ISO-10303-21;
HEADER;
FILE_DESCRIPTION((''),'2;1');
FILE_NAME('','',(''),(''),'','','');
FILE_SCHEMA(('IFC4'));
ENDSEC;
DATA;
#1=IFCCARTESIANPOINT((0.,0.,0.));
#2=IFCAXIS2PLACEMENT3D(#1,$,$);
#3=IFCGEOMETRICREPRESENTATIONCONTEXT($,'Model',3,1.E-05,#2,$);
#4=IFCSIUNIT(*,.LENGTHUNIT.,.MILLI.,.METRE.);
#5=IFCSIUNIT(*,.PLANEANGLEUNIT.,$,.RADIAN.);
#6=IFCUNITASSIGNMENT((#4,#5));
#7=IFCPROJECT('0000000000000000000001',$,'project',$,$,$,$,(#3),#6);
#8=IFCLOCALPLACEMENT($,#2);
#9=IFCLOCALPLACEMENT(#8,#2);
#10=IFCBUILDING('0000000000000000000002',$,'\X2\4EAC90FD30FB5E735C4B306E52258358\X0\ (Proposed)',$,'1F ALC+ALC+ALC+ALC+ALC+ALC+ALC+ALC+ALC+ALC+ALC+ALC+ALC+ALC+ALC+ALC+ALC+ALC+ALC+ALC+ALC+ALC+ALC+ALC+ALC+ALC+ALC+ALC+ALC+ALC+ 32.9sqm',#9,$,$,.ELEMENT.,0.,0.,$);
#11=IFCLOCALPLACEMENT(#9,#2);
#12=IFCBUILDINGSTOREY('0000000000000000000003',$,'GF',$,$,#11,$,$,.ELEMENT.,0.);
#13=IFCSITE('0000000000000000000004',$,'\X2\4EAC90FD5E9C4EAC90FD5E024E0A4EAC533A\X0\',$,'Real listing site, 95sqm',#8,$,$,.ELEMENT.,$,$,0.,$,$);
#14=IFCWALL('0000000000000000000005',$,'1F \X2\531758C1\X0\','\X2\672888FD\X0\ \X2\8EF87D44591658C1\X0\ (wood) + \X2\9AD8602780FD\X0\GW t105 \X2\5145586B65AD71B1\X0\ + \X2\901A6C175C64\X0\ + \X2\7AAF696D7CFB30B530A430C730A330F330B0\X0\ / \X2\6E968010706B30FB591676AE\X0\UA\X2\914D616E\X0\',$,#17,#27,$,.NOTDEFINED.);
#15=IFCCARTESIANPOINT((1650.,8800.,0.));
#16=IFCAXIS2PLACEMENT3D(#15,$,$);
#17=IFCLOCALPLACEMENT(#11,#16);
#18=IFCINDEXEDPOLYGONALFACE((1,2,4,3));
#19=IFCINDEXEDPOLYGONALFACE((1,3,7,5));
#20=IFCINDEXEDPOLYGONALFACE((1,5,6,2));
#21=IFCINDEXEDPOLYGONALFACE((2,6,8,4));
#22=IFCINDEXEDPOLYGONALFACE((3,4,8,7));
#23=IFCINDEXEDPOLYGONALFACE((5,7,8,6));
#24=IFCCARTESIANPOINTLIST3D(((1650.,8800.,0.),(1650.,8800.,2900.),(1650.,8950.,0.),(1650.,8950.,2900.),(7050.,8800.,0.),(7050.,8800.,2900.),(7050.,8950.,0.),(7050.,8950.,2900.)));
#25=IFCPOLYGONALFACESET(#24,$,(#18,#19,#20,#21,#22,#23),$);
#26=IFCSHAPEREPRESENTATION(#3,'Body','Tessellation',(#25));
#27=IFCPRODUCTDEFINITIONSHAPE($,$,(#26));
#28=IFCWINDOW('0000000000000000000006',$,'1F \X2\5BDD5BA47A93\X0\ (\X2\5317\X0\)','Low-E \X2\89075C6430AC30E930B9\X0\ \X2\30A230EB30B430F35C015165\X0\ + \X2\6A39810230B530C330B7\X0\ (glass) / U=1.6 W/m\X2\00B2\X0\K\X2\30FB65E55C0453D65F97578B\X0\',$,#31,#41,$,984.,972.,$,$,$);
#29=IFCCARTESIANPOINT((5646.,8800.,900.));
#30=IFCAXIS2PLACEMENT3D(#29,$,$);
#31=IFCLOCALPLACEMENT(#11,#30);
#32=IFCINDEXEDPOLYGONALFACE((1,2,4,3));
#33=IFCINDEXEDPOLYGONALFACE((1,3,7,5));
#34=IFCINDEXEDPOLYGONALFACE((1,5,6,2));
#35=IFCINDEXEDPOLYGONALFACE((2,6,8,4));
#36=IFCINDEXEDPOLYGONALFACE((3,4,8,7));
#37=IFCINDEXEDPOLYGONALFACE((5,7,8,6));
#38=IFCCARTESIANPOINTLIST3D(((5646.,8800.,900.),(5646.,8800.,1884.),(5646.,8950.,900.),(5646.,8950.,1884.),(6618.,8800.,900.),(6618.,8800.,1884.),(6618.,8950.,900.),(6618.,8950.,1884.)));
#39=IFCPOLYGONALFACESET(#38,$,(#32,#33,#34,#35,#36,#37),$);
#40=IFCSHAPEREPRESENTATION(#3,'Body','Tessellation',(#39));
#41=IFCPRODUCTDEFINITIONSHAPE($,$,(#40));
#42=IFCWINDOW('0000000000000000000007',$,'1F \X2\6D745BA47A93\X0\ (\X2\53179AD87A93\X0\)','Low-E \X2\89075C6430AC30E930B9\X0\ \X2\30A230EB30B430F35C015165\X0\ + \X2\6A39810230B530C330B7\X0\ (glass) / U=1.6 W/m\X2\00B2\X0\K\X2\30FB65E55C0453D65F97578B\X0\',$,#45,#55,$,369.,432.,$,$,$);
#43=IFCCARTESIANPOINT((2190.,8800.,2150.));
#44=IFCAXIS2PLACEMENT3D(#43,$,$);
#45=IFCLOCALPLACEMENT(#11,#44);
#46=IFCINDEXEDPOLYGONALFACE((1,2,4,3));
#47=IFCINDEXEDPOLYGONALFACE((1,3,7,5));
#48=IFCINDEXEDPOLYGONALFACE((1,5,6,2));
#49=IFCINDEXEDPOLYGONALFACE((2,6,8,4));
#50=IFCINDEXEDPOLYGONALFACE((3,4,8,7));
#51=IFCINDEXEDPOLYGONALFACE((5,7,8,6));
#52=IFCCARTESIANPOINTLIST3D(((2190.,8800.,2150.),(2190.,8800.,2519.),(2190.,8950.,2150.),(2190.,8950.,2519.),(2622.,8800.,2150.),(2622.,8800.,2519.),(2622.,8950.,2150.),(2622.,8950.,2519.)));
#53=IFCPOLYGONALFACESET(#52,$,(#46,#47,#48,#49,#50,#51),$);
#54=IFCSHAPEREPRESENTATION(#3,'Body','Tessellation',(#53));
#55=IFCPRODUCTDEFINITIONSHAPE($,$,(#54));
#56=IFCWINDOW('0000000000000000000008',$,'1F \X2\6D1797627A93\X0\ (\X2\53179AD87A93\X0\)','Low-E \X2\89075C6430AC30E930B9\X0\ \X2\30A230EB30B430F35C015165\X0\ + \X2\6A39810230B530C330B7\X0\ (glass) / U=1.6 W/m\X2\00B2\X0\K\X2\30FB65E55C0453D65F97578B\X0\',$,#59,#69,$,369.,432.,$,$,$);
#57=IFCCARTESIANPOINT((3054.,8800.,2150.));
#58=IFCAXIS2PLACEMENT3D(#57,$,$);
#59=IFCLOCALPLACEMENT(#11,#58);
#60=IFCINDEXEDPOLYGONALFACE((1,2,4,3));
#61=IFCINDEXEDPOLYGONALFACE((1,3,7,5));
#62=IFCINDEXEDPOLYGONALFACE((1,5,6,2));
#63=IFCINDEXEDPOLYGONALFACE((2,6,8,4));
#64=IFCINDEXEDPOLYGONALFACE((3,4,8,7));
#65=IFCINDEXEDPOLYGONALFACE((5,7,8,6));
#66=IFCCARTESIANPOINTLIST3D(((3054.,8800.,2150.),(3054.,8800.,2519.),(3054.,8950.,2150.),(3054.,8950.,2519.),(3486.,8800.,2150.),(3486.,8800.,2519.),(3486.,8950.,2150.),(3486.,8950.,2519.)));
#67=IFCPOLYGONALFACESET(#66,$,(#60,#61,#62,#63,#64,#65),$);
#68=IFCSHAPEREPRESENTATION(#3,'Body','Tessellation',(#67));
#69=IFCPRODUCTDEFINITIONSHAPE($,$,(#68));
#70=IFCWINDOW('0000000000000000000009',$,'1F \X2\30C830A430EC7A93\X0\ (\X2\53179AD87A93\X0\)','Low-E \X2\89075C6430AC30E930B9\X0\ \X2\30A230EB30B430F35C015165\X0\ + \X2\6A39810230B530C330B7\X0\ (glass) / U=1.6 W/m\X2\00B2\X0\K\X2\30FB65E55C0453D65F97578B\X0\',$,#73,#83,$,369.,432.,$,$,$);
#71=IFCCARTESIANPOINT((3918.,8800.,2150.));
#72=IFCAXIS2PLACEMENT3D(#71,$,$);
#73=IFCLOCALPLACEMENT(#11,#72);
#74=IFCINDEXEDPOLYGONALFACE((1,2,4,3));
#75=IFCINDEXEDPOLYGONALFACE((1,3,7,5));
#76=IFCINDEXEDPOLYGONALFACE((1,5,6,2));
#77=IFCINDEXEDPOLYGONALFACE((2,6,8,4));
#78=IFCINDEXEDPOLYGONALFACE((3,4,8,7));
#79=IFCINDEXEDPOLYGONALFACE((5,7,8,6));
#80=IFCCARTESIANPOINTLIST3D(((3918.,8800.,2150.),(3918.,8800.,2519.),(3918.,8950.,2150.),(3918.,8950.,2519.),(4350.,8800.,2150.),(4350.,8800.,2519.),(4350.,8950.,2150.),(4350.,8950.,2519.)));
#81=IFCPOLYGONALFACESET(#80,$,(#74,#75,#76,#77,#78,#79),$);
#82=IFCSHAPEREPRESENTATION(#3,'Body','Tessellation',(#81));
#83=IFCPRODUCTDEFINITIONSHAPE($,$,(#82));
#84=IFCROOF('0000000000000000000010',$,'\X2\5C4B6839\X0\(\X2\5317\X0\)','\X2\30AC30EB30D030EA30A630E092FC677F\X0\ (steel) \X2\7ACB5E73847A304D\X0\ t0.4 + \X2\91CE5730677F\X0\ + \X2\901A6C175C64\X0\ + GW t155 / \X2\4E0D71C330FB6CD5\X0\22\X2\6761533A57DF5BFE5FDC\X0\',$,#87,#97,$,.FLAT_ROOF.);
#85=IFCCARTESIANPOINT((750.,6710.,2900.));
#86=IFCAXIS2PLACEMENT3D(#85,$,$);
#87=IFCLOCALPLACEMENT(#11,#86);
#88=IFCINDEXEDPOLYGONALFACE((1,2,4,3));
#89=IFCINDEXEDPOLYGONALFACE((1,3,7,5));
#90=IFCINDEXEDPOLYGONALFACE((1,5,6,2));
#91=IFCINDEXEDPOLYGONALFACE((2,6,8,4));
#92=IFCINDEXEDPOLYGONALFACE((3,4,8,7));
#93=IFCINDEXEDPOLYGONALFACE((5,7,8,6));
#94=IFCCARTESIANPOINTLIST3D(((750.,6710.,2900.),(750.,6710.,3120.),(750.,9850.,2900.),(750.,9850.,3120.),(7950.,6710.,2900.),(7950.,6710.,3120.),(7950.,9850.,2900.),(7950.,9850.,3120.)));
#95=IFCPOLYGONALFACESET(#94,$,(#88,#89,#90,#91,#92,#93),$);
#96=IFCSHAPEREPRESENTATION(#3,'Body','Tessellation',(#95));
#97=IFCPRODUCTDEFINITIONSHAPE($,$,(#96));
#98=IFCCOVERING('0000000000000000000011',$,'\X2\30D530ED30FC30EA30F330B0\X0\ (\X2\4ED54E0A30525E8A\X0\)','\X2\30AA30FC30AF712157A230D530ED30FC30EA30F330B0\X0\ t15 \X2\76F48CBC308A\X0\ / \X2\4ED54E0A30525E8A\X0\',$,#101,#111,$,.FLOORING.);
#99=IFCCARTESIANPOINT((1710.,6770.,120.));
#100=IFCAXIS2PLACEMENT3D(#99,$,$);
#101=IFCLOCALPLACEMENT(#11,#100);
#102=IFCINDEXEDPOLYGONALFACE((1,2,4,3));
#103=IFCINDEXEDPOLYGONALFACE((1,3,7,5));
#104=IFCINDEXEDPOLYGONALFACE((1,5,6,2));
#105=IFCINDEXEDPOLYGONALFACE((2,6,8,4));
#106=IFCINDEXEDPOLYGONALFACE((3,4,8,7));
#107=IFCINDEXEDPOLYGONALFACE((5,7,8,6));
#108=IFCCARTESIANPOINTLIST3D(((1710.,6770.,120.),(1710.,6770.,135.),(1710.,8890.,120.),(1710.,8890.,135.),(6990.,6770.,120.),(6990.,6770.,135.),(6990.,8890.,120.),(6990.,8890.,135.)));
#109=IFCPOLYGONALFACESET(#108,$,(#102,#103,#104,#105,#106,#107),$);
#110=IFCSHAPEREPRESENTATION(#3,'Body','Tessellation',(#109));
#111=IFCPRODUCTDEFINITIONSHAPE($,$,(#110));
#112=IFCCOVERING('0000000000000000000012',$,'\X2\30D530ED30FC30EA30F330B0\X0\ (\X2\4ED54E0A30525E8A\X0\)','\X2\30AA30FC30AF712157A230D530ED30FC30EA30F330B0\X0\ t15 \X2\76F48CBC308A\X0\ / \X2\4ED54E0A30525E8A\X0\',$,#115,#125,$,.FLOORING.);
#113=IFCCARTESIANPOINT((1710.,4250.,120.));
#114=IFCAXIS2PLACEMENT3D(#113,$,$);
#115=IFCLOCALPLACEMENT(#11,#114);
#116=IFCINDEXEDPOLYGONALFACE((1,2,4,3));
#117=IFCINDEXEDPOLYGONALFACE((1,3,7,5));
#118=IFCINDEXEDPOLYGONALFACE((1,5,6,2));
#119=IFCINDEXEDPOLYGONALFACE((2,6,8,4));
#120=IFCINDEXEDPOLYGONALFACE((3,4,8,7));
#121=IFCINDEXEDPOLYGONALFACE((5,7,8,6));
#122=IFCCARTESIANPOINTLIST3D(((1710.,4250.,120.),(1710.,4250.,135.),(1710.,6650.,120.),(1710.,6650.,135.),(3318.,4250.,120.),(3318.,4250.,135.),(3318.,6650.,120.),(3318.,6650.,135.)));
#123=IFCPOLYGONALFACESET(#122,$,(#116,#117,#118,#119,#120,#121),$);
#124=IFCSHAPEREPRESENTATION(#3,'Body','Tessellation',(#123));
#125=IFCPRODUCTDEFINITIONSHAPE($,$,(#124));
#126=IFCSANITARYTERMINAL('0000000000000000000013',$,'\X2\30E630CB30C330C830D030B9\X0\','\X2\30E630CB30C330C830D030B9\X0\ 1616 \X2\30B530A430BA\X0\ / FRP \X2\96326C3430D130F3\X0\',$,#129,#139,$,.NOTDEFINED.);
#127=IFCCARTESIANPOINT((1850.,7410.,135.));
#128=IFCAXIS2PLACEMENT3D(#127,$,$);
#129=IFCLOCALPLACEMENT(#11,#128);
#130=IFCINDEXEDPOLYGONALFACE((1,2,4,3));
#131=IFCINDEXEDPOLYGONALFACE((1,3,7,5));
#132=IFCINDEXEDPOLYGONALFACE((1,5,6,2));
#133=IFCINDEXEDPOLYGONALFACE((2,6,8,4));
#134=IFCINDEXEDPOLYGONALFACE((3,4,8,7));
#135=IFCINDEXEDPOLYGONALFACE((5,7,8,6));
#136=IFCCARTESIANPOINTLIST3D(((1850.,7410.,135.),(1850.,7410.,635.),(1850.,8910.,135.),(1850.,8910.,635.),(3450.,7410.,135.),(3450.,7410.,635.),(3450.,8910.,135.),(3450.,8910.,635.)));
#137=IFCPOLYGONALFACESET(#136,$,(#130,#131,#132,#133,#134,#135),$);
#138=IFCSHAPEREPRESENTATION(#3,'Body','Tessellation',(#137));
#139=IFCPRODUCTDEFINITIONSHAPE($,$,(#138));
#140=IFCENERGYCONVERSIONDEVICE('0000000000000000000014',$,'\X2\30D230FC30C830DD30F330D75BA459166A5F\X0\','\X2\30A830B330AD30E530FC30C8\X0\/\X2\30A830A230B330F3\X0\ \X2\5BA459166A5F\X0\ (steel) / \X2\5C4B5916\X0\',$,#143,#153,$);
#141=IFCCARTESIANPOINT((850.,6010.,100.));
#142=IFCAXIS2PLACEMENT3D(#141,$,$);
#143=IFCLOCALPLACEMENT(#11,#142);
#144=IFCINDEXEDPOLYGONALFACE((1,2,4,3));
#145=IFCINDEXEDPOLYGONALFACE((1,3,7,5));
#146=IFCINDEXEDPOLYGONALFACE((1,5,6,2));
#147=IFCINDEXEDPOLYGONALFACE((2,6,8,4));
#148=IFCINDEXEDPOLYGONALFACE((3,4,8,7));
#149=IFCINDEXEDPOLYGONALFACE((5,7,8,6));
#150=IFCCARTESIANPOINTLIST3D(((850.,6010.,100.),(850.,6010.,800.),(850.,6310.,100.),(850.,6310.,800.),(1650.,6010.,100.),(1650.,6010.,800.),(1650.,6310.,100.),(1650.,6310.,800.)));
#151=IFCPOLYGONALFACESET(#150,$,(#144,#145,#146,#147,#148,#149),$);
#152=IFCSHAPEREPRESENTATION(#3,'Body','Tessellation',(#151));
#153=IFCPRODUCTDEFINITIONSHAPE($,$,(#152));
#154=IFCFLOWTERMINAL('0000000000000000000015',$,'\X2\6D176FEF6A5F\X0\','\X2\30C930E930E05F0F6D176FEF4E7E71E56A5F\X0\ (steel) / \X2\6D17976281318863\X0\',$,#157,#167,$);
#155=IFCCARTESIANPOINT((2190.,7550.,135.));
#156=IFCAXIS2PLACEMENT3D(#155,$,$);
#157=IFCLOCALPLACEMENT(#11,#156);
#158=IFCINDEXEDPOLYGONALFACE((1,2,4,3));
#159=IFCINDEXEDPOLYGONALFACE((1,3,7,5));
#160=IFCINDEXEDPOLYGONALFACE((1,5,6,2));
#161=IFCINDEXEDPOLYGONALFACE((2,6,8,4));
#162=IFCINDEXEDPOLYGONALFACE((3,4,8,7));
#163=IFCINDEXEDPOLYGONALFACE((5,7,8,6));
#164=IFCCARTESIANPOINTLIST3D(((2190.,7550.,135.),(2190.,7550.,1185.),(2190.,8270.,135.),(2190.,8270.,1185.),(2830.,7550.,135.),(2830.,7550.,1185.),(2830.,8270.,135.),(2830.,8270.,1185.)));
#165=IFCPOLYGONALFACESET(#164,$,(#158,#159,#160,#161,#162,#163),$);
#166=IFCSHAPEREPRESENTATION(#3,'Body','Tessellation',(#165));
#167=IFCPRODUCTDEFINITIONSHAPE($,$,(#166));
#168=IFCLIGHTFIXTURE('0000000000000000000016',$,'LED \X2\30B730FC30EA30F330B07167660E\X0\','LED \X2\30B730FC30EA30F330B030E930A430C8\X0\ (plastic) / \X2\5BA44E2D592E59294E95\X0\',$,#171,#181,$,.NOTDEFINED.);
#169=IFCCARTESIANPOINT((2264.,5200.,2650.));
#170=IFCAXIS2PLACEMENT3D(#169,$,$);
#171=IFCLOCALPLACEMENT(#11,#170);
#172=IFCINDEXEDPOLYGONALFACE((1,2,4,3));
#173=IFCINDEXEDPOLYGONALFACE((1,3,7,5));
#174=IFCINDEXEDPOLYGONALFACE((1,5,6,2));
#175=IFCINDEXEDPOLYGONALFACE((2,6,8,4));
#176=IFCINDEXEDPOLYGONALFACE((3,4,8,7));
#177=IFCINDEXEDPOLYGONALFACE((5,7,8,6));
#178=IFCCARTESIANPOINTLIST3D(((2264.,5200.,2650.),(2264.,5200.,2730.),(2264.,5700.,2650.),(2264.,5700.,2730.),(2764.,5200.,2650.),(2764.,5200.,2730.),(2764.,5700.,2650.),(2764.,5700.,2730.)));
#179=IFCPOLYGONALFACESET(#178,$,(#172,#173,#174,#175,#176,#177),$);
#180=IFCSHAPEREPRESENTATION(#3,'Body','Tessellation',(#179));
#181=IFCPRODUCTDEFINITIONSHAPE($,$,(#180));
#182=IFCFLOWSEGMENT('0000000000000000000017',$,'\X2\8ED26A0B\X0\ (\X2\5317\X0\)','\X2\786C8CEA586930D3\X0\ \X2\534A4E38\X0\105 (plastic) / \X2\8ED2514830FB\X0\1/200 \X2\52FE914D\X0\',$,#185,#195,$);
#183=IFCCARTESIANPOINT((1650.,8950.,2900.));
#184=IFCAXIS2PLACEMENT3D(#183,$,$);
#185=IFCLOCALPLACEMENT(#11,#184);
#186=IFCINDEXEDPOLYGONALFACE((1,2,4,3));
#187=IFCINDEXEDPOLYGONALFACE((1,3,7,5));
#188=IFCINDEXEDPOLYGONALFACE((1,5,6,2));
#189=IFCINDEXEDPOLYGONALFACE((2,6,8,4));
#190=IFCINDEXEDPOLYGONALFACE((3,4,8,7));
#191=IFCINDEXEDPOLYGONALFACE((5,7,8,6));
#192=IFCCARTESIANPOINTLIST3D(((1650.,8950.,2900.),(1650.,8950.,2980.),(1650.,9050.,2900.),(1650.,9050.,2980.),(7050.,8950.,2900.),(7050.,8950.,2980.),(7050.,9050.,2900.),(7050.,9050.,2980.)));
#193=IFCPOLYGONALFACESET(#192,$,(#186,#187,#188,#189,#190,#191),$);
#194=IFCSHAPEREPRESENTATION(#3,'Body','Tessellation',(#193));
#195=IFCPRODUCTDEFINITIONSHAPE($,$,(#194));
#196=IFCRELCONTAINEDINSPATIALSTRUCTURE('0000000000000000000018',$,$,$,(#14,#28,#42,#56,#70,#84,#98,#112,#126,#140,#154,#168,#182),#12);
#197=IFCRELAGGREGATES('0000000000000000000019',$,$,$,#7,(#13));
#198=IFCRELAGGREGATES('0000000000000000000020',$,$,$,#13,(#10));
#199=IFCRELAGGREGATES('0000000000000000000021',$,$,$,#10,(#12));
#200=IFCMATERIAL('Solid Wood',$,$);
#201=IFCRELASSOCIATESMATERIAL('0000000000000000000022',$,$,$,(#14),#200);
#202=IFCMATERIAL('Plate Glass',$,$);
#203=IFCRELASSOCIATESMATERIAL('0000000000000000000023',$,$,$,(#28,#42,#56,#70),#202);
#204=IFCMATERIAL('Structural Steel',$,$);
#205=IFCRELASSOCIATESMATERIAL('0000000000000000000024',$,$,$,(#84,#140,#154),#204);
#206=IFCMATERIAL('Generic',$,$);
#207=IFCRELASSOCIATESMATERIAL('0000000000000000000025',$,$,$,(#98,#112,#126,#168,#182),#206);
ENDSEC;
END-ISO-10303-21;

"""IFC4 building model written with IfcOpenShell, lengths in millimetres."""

from ifc_helpers import new_model, si_unit, frame, frame_2d, origin, place, context, project, spatial, rectangle, extrude, material, element, fill, save


model = new_model("IFC4")

# Units and contexts
model_context = context("Model", 3, precision=1e-05, world=origin())
ifc_project = project(units=[si_unit("LENGTHUNIT", "METRE", prefix="MILLI"), si_unit("PLANEANGLEUNIT", "RADIAN")], contexts=[model_context])

# Site, building, storey
site_placement = place(None, origin())
site = spatial("IfcSite", under=ifc_project, at=site_placement, Name="京都府京都市上京区", ObjectType="Real listing site, 95sqm", CompositionType="ELEMENT", RefElevation=0.0)
building_placement = place(site_placement, origin())
building = spatial("IfcBuilding", under=site, at=building_placement, Name="京都・平屋の別荘 (Proposed)", ObjectType="1F ALC+ALC+ALC+ALC+ALC+ALC+ALC+ALC+ALC+ALC+ALC+ALC+ALC+ALC+ALC+ALC+ALC+ALC+ALC+ALC+ALC+ALC+ALC+ALC+ALC+ALC+ALC+ALC+ALC+ALC+ 32.9sqm", CompositionType="ELEMENT", ElevationOfRefHeight=0.0, ElevationOfTerrain=0.0)
storey_placement = place(building_placement, origin())
storey = spatial("IfcBuildingStorey", under=building, at=storey_placement, Name="GF", CompositionType="ELEMENT", Elevation=0.0)

# Shared definitions
ifc_material_1 = material(Name="Solid Wood")

# Wall, openings, windows
wall_1_placement = place(storey_placement, frame((1650.0, 8800.0, 0.0)))
wall_1 = element("IfcWall", 1, at=wall_1_placement, inside=storey, material=ifc_material_1, Name="1F 北壁", Description="木製 軸組外壁 (wood) + 高性能GW t105 充填断熱 + 通気層 + 窯業系サイディング / 準耐火・外皮UA配慮", PredefinedType="NOTDEFINED", context=model_context, shape_type="SweptSolid", body=[
    extrude(rectangle(XDim=5400.0, YDim=150.0, at=frame_2d((2700.0, 75.0))), frame((1650.0, 8800.0, 0.0)), (0.0, 0.0, 1.0), 2900.0),
])
opening_1_placement = place(storey_placement, frame((5646.0, 8800.0, 900.0)))
opening_1 = element("IfcOpeningElement", 2, at=opening_1_placement, cuts=wall_1, PredefinedType="NOTDEFINED", context=model_context, shape_type="SweptSolid", body=[
    extrude(rectangle(XDim=972.0, YDim=150.0, at=frame_2d((486.0, 75.0))), frame((5646.0, 8800.0, 900.0)), (0.0, 0.0, 1.0), 984.0),
])
opening_2_placement = place(storey_placement, frame((2190.0, 8800.0, 2150.0)))
opening_2 = element("IfcOpeningElement", 3, at=opening_2_placement, cuts=wall_1, PredefinedType="NOTDEFINED", context=model_context, shape_type="SweptSolid", body=[
    extrude(rectangle(XDim=432.0, YDim=150.0, at=frame_2d((216.0, 75.0))), frame((2190.0, 8800.0, 2150.0)), (0.0, 0.0, 1.0), 369.0),
])
opening_3_placement = place(storey_placement, frame((3054.0, 8800.0, 2150.0)))
opening_3 = element("IfcOpeningElement", 4, at=opening_3_placement, cuts=wall_1, PredefinedType="NOTDEFINED", context=model_context, shape_type="SweptSolid", body=[
    extrude(rectangle(XDim=432.0, YDim=150.0, at=frame_2d((216.0, 75.0))), frame((3054.0, 8800.0, 2150.0)), (0.0, 0.0, 1.0), 369.0),
])
opening_4_placement = place(storey_placement, frame((3918.0, 8800.0, 2150.0)))
opening_4 = element("IfcOpeningElement", 5, at=opening_4_placement, cuts=wall_1, PredefinedType="NOTDEFINED", context=model_context, shape_type="SweptSolid", body=[
    extrude(rectangle(XDim=432.0, YDim=150.0, at=frame_2d((216.0, 75.0))), frame((3918.0, 8800.0, 2150.0)), (0.0, 0.0, 1.0), 369.0),
])
ifc_material_2 = material(Name="Plate Glass")
window_1_placement = place(storey_placement, frame((5646.0, 8800.0, 900.0)))
window_1 = element("IfcWindow", 6, at=window_1_placement, inside=storey, material=ifc_material_2, Name="1F 寝室窓 (北)", Description="Low-E 複層ガラス アルゴン封入 + 樹脂サッシ (glass) / U=1.6 W/m²K・日射取得型", OverallHeight=984.0, OverallWidth=972.0, context=model_context, shape_type="SweptSolid", body=[
    extrude(rectangle(XDim=972.0, YDim=150.0, at=frame_2d((486.0, 75.0))), frame((5646.0, 8800.0, 900.0)), (0.0, 0.0, 1.0), 984.0),
])
fill(opening_1, window_1)
window_2_placement = place(storey_placement, frame((2190.0, 8800.0, 2150.0)))
window_2 = element("IfcWindow", 7, at=window_2_placement, inside=storey, material=ifc_material_2, Name="1F 浴室窓 (北高窓)", Description="Low-E 複層ガラス アルゴン封入 + 樹脂サッシ (glass) / U=1.6 W/m²K・日射取得型", OverallHeight=369.0, OverallWidth=432.0, context=model_context, shape_type="SweptSolid", body=[
    extrude(rectangle(XDim=432.0, YDim=150.0, at=frame_2d((216.0, 75.0))), frame((2190.0, 8800.0, 2150.0)), (0.0, 0.0, 1.0), 369.0),
])
fill(opening_2, window_2)
window_3_placement = place(storey_placement, frame((3054.0, 8800.0, 2150.0)))
window_3 = element("IfcWindow", 8, at=window_3_placement, inside=storey, material=ifc_material_2, Name="1F 洗面窓 (北高窓)", Description="Low-E 複層ガラス アルゴン封入 + 樹脂サッシ (glass) / U=1.6 W/m²K・日射取得型", OverallHeight=369.0, OverallWidth=432.0, context=model_context, shape_type="SweptSolid", body=[
    extrude(rectangle(XDim=432.0, YDim=150.0, at=frame_2d((216.0, 75.0))), frame((3054.0, 8800.0, 2150.0)), (0.0, 0.0, 1.0), 369.0),
])
fill(opening_3, window_3)
window_4_placement = place(storey_placement, frame((3918.0, 8800.0, 2150.0)))
window_4 = element("IfcWindow", 9, at=window_4_placement, inside=storey, material=ifc_material_2, Name="1F トイレ窓 (北高窓)", Description="Low-E 複層ガラス アルゴン封入 + 樹脂サッシ (glass) / U=1.6 W/m²K・日射取得型", OverallHeight=369.0, OverallWidth=432.0, context=model_context, shape_type="SweptSolid", body=[
    extrude(rectangle(XDim=432.0, YDim=150.0, at=frame_2d((216.0, 75.0))), frame((3918.0, 8800.0, 2150.0)), (0.0, 0.0, 1.0), 369.0),
])
fill(opening_4, window_4)

# Roof
ifc_material_3 = material(Name="Structural Steel")
roof_placement = place(storey_placement, frame((750.0, 6710.0, 2900.0)))
element("IfcRoof", 10, at=roof_placement, inside=storey, material=ifc_material_3, Name="屋根(北)", Description="ガルバリウム鋼板 (steel) 立平葺き t0.4 + 野地板 + 通気層 + GW t155 / 不燃・法22条区域対応", PredefinedType="FLAT_ROOF", context=model_context, shape_type="SweptSolid", body=[
    extrude(rectangle(XDim=7200.0, YDim=3140.0, at=frame_2d((3600.0, 1570.0))), frame((750.0, 6710.0, 2900.0)), (0.0, 0.0, 1.0), 220.0),
])

# Coverings
ifc_material_4 = material(Name="Generic")
covering_1_placement = place(storey_placement, frame((1710.0, 6770.0, 120.0)))
element("IfcCovering", 11, at=covering_1_placement, inside=storey, material=ifc_material_4, Name="フローリング (仕上げ床)", Description="オーク無垢フローリング t15 直貼り / 仕上げ床", PredefinedType="FLOORING", context=model_context, shape_type="SweptSolid", body=[
    extrude(rectangle(XDim=5280.0, YDim=2120.0, at=frame_2d((2640.0, 1060.0))), frame((1710.0, 6770.0, 120.0)), (0.0, 0.0, 1.0), 15.0),
])
covering_2_placement = place(storey_placement, frame((1710.0, 4250.0, 120.0)))
element("IfcCovering", 12, at=covering_2_placement, inside=storey, material=ifc_material_4, Name="フローリング (仕上げ床)", Description="オーク無垢フローリング t15 直貼り / 仕上げ床", PredefinedType="FLOORING", context=model_context, shape_type="SweptSolid", body=[
    extrude(rectangle(XDim=1608.0, YDim=2400.0, at=frame_2d((804.0, 1200.0))), frame((1710.0, 4250.0, 120.0)), (0.0, 0.0, 1.0), 15.0),
])

# Sanitary terminal
sanitary_terminal_placement = place(storey_placement, frame((1850.0, 7410.0, 135.0)))
element("IfcSanitaryTerminal", 13, at=sanitary_terminal_placement, inside=storey, material=ifc_material_4, Name="ユニットバス", Description="ユニットバス 1616 サイズ / FRP 防水パン", PredefinedType="NOTDEFINED", context=model_context, shape_type="SweptSolid", body=[
    extrude(rectangle(XDim=1600.0, YDim=1500.0, at=frame_2d((800.0, 750.0))), frame((1850.0, 7410.0, 135.0)), (0.0, 0.0, 1.0), 500.0),
])

# Energy conversion device
energy_conversion_device_placement = place(storey_placement, frame((850.0, 6010.0, 100.0)))
element("IfcEnergyConversionDevice", 14, at=energy_conversion_device_placement, inside=storey, material=ifc_material_3, Name="ヒートポンプ室外機", Description="エコキュート/エアコン 室外機 (steel) / 屋外", context=model_context, shape_type="SweptSolid", body=[
    extrude(rectangle(XDim=800.0, YDim=300.0, at=frame_2d((400.0, 150.0))), frame((850.0, 6010.0, 100.0)), (0.0, 0.0, 1.0), 700.0),
])

# Flow terminal
flow_terminal_placement = place(storey_placement, frame((2190.0, 7550.0, 135.0)))
element("IfcFlowTerminal", 15, at=flow_terminal_placement, inside=storey, material=ifc_material_3, Name="洗濯機", Description="ドラム式洗濯乾燥機 (steel) / 洗面脱衣", context=model_context, shape_type="SweptSolid", body=[
    extrude(rectangle(XDim=640.0, YDim=720.0, at=frame_2d((320.0, 360.0))), frame((2190.0, 7550.0, 135.0)), (0.0, 0.0, 1.0), 1050.0),
])

# Light fixture
light_fixture_placement = place(storey_placement, frame((2264.0, 5200.0, 2650.0)))
element("IfcLightFixture", 16, at=light_fixture_placement, inside=storey, material=ifc_material_4, Name="LED シーリング照明", Description="LED シーリングライト (plastic) / 室中央天井", PredefinedType="NOTDEFINED", context=model_context, shape_type="SweptSolid", body=[
    extrude(rectangle(XDim=500.0, YDim=500.0, at=frame_2d((250.0, 250.0))), frame((2264.0, 5200.0, 2650.0)), (0.0, 0.0, 1.0), 80.0),
])

# Flow segment
flow_segment_1_placement = place(storey_placement, frame((1650.0, 8950.0, 2900.0)))
element("IfcFlowSegment", 17, at=flow_segment_1_placement, inside=storey, material=ifc_material_4, Name="軒樋 (北)", Description="硬質塩ビ 半丸105 (plastic) / 軒先・1/200 勾配", context=model_context, shape_type="SweptSolid", body=[
    extrude(rectangle(XDim=5400.0, YDim=100.0, at=frame_2d((2700.0, 50.0))), frame((1650.0, 8950.0, 2900.0)), (0.0, 0.0, 1.0), 80.0),
])

save(model, "model.ifc")
